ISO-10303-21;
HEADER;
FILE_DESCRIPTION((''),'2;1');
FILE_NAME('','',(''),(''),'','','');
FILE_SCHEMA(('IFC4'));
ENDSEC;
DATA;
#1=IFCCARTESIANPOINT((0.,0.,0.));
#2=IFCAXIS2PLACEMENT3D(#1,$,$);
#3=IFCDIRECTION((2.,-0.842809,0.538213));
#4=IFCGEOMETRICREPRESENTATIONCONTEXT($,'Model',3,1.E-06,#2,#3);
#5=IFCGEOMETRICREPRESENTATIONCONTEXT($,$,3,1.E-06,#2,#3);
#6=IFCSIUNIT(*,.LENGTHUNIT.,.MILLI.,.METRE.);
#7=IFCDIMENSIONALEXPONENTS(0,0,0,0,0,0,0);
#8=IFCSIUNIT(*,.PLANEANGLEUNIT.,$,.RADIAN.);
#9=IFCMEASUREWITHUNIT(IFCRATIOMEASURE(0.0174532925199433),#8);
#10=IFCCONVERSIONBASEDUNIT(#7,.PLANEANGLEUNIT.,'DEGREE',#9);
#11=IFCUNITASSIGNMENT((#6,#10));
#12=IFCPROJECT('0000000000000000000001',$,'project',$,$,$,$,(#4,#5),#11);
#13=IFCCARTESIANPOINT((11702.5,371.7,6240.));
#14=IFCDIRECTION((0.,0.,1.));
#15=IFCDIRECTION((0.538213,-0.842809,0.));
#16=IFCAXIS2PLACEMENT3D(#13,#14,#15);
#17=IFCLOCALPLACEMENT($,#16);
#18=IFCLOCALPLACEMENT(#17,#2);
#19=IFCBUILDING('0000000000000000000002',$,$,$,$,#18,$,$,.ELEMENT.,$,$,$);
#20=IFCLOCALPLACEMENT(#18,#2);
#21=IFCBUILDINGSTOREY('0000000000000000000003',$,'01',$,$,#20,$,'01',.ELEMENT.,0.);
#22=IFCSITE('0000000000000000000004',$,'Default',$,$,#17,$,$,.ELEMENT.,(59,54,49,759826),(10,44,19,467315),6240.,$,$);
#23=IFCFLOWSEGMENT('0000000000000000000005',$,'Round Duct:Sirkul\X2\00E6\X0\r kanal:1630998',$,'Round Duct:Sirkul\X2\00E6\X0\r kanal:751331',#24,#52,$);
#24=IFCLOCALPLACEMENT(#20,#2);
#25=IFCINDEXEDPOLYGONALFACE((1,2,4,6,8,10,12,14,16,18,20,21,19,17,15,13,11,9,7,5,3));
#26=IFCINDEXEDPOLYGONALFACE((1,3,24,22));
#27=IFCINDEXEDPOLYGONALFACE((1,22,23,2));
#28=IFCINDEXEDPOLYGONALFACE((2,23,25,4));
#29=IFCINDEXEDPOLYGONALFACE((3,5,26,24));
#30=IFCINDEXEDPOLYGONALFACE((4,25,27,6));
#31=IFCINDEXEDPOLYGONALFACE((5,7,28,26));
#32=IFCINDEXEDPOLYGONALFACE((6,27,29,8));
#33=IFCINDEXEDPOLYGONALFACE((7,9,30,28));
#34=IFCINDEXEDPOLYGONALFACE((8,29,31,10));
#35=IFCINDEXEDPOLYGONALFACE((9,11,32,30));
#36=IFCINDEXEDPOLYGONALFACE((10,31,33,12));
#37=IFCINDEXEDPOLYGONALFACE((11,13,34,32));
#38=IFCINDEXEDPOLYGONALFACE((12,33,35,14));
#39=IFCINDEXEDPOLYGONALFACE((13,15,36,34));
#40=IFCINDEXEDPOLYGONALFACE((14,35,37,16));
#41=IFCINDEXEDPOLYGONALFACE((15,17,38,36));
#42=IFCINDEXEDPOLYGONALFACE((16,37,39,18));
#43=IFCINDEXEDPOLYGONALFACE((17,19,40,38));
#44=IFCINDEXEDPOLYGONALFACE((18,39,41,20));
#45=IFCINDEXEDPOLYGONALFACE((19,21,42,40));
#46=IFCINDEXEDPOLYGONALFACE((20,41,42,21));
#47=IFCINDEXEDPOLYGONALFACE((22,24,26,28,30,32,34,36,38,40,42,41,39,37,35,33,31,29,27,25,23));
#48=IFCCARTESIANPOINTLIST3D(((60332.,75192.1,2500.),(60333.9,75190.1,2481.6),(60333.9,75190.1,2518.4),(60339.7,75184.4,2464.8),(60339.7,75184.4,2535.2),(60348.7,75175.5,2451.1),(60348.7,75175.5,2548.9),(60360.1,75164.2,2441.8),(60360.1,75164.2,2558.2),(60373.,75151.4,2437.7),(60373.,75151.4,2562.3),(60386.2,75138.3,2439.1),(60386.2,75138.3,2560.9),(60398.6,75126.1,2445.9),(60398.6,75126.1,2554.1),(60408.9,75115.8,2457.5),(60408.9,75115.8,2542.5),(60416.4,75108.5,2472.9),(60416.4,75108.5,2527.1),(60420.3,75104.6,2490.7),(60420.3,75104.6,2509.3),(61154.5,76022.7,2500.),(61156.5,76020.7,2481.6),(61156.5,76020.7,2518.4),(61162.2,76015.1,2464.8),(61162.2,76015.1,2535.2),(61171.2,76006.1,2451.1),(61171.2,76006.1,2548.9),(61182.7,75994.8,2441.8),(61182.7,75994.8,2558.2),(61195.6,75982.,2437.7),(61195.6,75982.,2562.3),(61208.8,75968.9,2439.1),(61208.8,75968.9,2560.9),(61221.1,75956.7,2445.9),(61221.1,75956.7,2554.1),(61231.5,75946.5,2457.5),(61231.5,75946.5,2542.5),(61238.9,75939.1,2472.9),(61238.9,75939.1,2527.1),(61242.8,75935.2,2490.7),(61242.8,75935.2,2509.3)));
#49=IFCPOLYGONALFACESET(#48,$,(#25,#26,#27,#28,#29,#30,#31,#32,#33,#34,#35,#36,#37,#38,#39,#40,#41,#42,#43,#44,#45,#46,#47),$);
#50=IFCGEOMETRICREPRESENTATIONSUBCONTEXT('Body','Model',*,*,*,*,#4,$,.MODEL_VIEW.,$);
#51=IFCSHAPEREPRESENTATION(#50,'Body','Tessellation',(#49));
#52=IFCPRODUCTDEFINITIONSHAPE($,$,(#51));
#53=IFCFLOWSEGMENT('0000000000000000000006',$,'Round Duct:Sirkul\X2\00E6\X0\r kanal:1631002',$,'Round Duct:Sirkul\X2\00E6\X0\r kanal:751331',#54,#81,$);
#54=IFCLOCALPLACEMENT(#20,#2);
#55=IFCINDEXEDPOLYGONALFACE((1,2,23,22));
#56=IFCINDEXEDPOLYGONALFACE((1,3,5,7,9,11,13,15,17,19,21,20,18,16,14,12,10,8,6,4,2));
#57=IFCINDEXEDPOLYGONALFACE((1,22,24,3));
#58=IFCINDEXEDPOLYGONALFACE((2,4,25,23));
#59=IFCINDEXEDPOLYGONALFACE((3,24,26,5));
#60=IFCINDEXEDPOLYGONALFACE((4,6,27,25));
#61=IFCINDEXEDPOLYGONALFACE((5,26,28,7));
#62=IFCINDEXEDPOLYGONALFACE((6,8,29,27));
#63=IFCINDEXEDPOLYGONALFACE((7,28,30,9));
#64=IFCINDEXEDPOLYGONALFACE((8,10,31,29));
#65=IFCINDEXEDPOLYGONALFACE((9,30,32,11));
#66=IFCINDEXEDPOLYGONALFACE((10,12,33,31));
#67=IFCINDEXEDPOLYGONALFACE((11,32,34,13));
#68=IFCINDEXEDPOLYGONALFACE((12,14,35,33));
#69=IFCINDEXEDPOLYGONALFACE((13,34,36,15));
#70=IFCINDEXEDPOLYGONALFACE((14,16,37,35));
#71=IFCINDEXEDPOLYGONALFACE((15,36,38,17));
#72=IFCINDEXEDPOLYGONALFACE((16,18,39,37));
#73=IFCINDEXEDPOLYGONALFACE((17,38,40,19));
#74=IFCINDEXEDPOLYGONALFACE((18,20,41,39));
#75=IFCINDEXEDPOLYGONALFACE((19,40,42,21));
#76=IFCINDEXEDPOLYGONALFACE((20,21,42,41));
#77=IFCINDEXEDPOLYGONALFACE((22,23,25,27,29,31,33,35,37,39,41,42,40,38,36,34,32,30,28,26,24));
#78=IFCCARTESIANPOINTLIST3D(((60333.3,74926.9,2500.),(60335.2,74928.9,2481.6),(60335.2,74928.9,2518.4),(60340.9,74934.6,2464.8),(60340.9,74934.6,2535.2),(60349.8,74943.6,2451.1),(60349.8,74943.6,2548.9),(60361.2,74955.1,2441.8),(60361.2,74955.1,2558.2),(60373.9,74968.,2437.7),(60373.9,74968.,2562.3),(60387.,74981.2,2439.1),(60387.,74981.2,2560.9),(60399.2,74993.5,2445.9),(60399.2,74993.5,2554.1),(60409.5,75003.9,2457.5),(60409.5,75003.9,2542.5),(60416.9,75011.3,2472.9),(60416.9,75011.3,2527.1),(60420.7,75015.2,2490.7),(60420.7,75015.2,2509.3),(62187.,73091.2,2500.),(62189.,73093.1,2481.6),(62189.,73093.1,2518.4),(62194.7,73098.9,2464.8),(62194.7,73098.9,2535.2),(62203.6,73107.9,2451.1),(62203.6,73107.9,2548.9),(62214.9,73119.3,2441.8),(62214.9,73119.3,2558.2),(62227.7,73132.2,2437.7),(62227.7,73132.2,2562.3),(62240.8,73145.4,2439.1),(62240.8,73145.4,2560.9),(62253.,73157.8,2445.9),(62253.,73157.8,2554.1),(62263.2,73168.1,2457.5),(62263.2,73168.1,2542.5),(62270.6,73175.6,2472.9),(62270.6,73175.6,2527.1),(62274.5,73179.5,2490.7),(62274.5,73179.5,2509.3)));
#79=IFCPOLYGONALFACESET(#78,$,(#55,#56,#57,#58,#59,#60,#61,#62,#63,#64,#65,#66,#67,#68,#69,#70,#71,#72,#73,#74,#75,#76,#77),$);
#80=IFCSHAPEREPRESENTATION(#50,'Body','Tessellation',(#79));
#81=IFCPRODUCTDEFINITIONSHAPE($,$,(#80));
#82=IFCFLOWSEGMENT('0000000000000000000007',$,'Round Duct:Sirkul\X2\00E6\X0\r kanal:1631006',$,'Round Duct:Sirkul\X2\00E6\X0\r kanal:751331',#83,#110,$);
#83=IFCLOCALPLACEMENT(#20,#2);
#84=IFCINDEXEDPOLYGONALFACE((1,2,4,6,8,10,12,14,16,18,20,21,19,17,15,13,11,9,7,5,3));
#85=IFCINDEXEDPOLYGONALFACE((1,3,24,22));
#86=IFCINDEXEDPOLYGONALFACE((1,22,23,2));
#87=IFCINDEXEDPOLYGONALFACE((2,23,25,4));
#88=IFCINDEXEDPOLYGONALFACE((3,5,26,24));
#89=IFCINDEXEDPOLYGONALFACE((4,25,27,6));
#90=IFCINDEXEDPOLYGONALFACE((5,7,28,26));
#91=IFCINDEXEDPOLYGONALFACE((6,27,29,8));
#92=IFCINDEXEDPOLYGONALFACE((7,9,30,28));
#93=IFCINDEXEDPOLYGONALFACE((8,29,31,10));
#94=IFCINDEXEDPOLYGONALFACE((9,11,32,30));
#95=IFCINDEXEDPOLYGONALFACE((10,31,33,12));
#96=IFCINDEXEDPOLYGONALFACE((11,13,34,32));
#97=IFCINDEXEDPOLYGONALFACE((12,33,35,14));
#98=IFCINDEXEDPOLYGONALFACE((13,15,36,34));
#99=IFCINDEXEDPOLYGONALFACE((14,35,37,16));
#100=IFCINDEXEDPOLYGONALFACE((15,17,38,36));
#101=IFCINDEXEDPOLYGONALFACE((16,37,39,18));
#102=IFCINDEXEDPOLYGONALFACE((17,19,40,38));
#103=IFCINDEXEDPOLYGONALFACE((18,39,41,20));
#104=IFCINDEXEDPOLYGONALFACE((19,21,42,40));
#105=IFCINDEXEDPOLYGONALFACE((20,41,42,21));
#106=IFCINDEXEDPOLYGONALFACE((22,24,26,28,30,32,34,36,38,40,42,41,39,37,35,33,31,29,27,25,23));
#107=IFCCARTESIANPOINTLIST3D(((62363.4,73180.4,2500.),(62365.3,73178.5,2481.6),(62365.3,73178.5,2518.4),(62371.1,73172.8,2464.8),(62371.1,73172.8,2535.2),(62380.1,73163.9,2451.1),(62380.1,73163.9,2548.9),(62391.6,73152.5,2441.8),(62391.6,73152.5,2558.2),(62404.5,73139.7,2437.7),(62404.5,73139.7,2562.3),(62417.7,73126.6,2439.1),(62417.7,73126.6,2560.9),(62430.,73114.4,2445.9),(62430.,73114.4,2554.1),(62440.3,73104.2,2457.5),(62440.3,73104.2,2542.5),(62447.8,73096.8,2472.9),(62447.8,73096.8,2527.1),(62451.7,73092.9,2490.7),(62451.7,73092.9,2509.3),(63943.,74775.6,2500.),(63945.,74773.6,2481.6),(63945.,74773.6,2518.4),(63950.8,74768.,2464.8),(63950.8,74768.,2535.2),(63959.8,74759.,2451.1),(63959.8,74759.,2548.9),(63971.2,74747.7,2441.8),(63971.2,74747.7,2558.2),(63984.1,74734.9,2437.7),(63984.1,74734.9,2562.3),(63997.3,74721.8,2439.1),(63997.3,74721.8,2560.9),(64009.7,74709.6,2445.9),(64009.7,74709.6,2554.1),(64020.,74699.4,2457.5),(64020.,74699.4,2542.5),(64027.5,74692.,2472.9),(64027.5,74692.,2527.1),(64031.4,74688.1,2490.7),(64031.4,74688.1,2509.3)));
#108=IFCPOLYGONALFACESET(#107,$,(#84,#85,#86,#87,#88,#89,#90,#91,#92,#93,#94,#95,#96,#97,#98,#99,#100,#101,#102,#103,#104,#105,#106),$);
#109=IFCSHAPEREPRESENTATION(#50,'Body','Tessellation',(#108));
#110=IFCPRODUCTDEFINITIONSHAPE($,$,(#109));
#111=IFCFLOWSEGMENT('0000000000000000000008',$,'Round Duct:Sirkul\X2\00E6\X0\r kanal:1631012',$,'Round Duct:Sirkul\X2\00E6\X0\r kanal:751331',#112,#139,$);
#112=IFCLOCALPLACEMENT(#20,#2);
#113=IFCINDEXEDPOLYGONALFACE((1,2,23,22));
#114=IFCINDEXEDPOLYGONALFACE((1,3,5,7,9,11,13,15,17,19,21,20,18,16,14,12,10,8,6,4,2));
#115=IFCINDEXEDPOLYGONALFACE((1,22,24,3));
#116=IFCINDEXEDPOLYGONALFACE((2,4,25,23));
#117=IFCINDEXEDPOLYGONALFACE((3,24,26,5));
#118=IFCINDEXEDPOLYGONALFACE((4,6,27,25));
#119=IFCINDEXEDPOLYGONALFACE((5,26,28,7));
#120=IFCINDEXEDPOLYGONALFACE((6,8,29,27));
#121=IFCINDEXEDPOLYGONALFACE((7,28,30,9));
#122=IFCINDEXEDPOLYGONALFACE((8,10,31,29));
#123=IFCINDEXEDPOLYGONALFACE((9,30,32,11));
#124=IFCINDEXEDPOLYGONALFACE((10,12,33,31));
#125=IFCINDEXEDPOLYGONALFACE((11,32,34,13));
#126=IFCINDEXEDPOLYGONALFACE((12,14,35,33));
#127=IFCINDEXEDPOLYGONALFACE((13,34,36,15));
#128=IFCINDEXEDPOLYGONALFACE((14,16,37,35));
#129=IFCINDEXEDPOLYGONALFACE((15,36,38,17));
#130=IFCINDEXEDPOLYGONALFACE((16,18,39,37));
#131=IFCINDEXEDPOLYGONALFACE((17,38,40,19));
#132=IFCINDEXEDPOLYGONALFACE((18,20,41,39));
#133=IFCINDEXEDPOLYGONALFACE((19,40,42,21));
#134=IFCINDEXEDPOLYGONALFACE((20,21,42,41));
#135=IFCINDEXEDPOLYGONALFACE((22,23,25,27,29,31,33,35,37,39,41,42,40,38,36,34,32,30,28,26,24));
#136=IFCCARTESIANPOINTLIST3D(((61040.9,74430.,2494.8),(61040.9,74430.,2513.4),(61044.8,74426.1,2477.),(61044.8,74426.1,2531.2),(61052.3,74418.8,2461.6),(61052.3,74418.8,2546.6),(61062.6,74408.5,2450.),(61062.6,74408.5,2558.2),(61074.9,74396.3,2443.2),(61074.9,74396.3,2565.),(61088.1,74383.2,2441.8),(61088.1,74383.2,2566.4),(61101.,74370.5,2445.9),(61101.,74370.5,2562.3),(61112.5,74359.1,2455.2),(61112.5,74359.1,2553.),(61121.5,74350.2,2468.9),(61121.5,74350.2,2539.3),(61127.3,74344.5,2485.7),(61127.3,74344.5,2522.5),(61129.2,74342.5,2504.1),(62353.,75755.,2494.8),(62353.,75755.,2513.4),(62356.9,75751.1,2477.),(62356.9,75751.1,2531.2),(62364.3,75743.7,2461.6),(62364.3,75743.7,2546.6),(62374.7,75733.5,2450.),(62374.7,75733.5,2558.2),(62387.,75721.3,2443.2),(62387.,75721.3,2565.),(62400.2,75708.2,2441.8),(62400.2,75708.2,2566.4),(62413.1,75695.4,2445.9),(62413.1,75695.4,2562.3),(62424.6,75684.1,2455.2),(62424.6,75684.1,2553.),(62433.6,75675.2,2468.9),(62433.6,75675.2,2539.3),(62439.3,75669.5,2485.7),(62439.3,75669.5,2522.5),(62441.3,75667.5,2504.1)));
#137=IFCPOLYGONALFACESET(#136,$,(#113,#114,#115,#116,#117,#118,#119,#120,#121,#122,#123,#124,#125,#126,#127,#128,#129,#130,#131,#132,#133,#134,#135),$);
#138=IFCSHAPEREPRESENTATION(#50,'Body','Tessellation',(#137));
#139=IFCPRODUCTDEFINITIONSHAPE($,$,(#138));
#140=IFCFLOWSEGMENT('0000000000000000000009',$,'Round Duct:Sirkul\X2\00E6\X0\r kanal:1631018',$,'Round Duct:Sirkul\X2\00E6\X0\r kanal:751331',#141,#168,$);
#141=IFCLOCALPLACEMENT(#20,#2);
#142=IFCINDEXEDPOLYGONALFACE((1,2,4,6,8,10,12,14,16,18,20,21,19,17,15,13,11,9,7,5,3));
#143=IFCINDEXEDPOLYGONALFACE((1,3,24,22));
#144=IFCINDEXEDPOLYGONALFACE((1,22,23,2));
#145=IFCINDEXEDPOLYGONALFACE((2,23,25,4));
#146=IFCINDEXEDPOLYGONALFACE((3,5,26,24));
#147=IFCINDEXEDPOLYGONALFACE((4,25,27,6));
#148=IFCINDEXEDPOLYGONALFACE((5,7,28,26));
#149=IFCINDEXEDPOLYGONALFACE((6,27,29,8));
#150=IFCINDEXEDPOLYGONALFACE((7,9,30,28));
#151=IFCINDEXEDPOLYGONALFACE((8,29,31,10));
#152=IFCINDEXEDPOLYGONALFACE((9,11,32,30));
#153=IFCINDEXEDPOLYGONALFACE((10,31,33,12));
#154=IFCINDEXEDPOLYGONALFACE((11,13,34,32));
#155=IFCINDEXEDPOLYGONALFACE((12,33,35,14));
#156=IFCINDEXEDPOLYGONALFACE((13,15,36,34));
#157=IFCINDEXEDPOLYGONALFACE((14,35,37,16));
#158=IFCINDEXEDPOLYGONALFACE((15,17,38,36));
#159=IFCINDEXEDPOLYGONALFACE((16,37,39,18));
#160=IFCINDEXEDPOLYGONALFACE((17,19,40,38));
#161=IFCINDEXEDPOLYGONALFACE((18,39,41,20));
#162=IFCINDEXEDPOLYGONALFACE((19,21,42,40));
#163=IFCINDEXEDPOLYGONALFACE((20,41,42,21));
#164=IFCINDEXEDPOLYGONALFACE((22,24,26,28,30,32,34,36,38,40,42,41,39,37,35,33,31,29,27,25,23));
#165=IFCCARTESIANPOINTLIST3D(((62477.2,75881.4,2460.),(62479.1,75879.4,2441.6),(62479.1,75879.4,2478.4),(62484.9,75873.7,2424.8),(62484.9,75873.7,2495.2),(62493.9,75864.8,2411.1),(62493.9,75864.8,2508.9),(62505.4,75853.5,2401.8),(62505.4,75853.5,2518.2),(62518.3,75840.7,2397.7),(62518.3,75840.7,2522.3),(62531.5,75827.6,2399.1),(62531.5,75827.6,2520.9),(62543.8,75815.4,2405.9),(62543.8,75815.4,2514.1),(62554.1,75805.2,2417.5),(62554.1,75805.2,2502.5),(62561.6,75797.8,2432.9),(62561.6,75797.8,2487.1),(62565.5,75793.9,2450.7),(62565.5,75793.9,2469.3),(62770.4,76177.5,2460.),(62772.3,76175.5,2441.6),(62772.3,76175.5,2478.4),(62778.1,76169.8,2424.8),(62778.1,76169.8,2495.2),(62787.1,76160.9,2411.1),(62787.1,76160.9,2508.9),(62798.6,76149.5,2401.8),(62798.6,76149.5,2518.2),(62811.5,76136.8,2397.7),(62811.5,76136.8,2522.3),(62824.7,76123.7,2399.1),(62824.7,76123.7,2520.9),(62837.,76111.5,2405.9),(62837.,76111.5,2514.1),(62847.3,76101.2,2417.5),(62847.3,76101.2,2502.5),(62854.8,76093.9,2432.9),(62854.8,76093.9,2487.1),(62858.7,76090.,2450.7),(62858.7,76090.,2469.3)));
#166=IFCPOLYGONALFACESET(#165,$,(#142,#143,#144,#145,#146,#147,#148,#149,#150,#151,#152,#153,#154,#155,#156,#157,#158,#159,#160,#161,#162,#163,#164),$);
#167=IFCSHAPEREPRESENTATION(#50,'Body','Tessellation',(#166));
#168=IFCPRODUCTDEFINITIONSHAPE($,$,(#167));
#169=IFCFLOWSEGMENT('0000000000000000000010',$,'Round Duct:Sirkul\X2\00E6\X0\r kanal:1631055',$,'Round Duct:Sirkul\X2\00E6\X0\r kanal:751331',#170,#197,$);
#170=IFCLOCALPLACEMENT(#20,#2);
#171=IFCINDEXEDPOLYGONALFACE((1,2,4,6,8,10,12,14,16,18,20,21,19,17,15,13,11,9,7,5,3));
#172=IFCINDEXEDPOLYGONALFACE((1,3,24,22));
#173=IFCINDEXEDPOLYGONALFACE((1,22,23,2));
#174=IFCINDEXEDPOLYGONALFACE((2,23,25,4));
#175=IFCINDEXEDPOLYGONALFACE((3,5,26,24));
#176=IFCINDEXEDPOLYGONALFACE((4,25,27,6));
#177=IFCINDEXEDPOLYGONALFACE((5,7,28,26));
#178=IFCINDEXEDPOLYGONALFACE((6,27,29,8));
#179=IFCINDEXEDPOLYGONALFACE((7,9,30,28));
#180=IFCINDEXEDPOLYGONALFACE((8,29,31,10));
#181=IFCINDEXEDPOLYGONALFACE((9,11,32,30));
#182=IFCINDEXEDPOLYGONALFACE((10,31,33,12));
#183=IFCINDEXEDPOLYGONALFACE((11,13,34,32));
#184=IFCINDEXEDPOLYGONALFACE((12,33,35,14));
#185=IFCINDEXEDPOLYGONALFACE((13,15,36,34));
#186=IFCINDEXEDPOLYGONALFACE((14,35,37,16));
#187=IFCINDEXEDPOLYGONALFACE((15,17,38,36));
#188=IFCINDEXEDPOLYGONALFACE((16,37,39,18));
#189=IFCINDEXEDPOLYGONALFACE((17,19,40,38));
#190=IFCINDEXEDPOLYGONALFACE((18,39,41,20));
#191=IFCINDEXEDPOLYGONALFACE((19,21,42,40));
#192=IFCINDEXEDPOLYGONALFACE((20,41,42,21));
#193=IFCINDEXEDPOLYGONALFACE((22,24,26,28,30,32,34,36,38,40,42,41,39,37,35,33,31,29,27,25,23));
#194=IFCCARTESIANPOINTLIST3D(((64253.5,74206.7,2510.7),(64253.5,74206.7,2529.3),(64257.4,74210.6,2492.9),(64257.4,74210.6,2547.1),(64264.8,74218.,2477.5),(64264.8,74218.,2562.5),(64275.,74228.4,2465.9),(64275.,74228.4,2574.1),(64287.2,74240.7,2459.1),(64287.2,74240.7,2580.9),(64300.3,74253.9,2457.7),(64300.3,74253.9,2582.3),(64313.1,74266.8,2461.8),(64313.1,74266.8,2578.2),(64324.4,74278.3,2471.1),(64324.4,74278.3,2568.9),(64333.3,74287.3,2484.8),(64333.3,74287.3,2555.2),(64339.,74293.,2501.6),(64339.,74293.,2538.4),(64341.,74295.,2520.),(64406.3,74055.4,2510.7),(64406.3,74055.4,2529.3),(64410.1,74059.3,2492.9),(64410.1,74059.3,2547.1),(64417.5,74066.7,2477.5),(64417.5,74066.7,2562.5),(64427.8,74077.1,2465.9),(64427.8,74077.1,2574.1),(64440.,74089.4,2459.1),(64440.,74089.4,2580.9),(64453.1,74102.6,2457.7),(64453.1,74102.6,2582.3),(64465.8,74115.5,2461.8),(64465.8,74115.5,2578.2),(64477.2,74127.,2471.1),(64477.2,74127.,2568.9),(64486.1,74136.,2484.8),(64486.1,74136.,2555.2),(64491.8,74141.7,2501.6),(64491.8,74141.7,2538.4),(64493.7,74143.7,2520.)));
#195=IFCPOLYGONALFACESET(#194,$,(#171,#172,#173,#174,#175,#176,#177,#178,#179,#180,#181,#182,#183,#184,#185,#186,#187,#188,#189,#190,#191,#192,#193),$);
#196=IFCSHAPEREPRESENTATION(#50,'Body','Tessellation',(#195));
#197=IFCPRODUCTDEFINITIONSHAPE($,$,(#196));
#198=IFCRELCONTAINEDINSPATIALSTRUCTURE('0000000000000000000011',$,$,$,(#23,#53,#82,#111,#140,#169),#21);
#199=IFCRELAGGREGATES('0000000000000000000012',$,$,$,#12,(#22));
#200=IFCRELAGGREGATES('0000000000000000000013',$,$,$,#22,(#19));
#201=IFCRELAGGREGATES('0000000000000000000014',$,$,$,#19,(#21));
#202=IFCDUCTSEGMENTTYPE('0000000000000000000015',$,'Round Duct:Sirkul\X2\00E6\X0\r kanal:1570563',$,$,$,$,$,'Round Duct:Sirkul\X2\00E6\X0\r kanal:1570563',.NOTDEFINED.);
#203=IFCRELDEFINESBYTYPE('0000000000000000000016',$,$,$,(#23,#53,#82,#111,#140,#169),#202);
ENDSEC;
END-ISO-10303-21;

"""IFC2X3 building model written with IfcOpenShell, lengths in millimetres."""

from ifc_helpers import new_model, entity, si_unit, converted_unit, direction, frame, origin, origin_2d_with_axis, place, context, subcontext, project, spatial, circle, extrude, type_object, element, save


model = new_model("IFC2X3")

# Units and contexts
model_context = context("Model", 3, precision=1e-06, world=origin(), true_north=direction((2.0, -0.842809, 0.538213)))
context_of_model = context(None, 3, precision=1e-06, world=origin(), true_north=direction((2.0, -0.842809, 0.538213)))
body_context = subcontext(model_context, "Body", "Model", "MODEL_VIEW")
ifc_project = project(units=[si_unit("LENGTHUNIT", "METRE", prefix="MILLI"), converted_unit("PLANEANGLEUNIT", "DEGREE", entity("IfcRatioMeasure", 0.0174532925199433), si_unit("PLANEANGLEUNIT", "RADIAN"), dimensions=[0, 0, 0, 0, 0, 0, 0])], contexts=[model_context, context_of_model])

# Site, building, storey
site_placement = place(None, frame((11702.5, 371.7, 6240.0), z_axis=(0.0, 0.0, 1.0), x_axis=(0.538213, -0.842809, 0.0)))
site = spatial("IfcSite", under=ifc_project, at=site_placement, Name="Default", CompositionType="ELEMENT", RefLatitude=(59, 54, 49, 759826), RefLongitude=(10, 44, 19, 467315), RefElevation=6240.0)
building_placement = place(site_placement, origin())
building = spatial("IfcBuilding", under=site, at=building_placement, CompositionType="ELEMENT")
storey_placement = place(building_placement, origin())
storey = spatial("IfcBuildingStorey", under=building, at=storey_placement, Name="01", LongName="01", CompositionType="ELEMENT", Elevation=0.0)

# Flow segments
duct_segment_type = type_object("IfcDuctSegmentType", Name="Round Duct:Sirkulær kanal:1570563", ElementType="Round Duct:Sirkulær kanal:1570563", PredefinedType="NOTDEFINED")
flow_segment_1_placement = place(storey_placement, origin())
element("IfcFlowSegment", 1, at=flow_segment_1_placement, inside=storey, type_object=duct_segment_type, Name="Round Duct:Sirkulær kanal:1630998", ObjectType="Round Duct:Sirkulær kanal:751331", context=body_context, shape_type="SweptSolid", body=[
    extrude(circle(Radius=62.5, at=origin_2d_with_axis()), frame((60376.4, 75148.1, 2500.0), z_axis=(0.703643, 0.710554, 0.0), x_axis=(-0.710554, 0.703643, 0.0)), (0.0, 0.0, 1.0), 1169.0),
])
flow_segment_2_placement = place(storey_placement, origin())
element("IfcFlowSegment", 2, at=flow_segment_2_placement, inside=storey, type_object=duct_segment_type, Name="Round Duct:Sirkulær kanal:1631002", ObjectType="Round Duct:Sirkulær kanal:751331", context=body_context, shape_type="SweptSolid", body=[
    extrude(circle(Radius=62.5, at=origin_2d_with_axis()), frame((62231.0, 73135.6, 2500.0), z_axis=(-0.710554, 0.703643, 0.0), x_axis=(-0.703643, -0.710554, 0.0)), (0.0, 0.0, 1.0), 2608.9),
])
flow_segment_3_placement = place(storey_placement, origin())
element("IfcFlowSegment", 3, at=flow_segment_3_placement, inside=storey, type_object=duct_segment_type, Name="Round Duct:Sirkulær kanal:1631006", ObjectType="Round Duct:Sirkulær kanal:751331", context=body_context, shape_type="SweptSolid", body=[
    extrude(circle(Radius=62.5, at=origin_2d_with_axis()), frame((62407.8, 73136.4, 2500.0), z_axis=(0.703643, 0.710554, 0.0), x_axis=(-0.710554, 0.703643, 0.0)), (0.0, 0.0, 1.0), 2245.0),
])
flow_segment_4_placement = place(storey_placement, origin())
element("IfcFlowSegment", 4, at=flow_segment_4_placement, inside=storey, type_object=duct_segment_type, Name="Round Duct:Sirkulær kanal:1631012", ObjectType="Round Duct:Sirkulær kanal:751331", context=body_context, shape_type="SweptSolid", body=[
    extrude(circle(Radius=62.5, at=origin_2d_with_axis()), frame((61084.8, 74386.5, 2504.1), z_axis=(0.703641, 0.710556, 0.0), x_axis=(0.710556, -0.703641, 0.0)), (0.0, 0.0, 1.0), 1864.7),
])
flow_segment_5_placement = place(storey_placement, origin())
element("IfcFlowSegment", 5, at=flow_segment_5_placement, inside=storey, type_object=duct_segment_type, Name="Round Duct:Sirkulær kanal:1631018", ObjectType="Round Duct:Sirkulær kanal:751331", context=body_context, shape_type="SweptSolid", body=[
    extrude(circle(Radius=62.5, at=origin_2d_with_axis()), frame((62521.6, 75837.4, 2460.0), z_axis=(0.70364, 0.710557, 0.0), x_axis=(-0.710557, 0.70364, 0.0)), (0.0, 0.0, 1.0), 416.7),
])
flow_segment_6_placement = place(storey_placement, origin())
element("IfcFlowSegment", 6, at=flow_segment_6_placement, inside=storey, type_object=duct_segment_type, Name="Round Duct:Sirkulær kanal:1631055", ObjectType="Round Duct:Sirkulær kanal:751331", context=body_context, shape_type="SweptSolid", body=[
    extrude(circle(Radius=62.5, at=origin_2d_with_axis()), frame((64449.8, 74099.3, 2520.0), z_axis=(-0.710554, 0.703643, 0.0), x_axis=(0.703643, 0.710554, 0.0)), (0.0, 0.0, 1.0), 215.0),
])

save(model, "model.ifc")
